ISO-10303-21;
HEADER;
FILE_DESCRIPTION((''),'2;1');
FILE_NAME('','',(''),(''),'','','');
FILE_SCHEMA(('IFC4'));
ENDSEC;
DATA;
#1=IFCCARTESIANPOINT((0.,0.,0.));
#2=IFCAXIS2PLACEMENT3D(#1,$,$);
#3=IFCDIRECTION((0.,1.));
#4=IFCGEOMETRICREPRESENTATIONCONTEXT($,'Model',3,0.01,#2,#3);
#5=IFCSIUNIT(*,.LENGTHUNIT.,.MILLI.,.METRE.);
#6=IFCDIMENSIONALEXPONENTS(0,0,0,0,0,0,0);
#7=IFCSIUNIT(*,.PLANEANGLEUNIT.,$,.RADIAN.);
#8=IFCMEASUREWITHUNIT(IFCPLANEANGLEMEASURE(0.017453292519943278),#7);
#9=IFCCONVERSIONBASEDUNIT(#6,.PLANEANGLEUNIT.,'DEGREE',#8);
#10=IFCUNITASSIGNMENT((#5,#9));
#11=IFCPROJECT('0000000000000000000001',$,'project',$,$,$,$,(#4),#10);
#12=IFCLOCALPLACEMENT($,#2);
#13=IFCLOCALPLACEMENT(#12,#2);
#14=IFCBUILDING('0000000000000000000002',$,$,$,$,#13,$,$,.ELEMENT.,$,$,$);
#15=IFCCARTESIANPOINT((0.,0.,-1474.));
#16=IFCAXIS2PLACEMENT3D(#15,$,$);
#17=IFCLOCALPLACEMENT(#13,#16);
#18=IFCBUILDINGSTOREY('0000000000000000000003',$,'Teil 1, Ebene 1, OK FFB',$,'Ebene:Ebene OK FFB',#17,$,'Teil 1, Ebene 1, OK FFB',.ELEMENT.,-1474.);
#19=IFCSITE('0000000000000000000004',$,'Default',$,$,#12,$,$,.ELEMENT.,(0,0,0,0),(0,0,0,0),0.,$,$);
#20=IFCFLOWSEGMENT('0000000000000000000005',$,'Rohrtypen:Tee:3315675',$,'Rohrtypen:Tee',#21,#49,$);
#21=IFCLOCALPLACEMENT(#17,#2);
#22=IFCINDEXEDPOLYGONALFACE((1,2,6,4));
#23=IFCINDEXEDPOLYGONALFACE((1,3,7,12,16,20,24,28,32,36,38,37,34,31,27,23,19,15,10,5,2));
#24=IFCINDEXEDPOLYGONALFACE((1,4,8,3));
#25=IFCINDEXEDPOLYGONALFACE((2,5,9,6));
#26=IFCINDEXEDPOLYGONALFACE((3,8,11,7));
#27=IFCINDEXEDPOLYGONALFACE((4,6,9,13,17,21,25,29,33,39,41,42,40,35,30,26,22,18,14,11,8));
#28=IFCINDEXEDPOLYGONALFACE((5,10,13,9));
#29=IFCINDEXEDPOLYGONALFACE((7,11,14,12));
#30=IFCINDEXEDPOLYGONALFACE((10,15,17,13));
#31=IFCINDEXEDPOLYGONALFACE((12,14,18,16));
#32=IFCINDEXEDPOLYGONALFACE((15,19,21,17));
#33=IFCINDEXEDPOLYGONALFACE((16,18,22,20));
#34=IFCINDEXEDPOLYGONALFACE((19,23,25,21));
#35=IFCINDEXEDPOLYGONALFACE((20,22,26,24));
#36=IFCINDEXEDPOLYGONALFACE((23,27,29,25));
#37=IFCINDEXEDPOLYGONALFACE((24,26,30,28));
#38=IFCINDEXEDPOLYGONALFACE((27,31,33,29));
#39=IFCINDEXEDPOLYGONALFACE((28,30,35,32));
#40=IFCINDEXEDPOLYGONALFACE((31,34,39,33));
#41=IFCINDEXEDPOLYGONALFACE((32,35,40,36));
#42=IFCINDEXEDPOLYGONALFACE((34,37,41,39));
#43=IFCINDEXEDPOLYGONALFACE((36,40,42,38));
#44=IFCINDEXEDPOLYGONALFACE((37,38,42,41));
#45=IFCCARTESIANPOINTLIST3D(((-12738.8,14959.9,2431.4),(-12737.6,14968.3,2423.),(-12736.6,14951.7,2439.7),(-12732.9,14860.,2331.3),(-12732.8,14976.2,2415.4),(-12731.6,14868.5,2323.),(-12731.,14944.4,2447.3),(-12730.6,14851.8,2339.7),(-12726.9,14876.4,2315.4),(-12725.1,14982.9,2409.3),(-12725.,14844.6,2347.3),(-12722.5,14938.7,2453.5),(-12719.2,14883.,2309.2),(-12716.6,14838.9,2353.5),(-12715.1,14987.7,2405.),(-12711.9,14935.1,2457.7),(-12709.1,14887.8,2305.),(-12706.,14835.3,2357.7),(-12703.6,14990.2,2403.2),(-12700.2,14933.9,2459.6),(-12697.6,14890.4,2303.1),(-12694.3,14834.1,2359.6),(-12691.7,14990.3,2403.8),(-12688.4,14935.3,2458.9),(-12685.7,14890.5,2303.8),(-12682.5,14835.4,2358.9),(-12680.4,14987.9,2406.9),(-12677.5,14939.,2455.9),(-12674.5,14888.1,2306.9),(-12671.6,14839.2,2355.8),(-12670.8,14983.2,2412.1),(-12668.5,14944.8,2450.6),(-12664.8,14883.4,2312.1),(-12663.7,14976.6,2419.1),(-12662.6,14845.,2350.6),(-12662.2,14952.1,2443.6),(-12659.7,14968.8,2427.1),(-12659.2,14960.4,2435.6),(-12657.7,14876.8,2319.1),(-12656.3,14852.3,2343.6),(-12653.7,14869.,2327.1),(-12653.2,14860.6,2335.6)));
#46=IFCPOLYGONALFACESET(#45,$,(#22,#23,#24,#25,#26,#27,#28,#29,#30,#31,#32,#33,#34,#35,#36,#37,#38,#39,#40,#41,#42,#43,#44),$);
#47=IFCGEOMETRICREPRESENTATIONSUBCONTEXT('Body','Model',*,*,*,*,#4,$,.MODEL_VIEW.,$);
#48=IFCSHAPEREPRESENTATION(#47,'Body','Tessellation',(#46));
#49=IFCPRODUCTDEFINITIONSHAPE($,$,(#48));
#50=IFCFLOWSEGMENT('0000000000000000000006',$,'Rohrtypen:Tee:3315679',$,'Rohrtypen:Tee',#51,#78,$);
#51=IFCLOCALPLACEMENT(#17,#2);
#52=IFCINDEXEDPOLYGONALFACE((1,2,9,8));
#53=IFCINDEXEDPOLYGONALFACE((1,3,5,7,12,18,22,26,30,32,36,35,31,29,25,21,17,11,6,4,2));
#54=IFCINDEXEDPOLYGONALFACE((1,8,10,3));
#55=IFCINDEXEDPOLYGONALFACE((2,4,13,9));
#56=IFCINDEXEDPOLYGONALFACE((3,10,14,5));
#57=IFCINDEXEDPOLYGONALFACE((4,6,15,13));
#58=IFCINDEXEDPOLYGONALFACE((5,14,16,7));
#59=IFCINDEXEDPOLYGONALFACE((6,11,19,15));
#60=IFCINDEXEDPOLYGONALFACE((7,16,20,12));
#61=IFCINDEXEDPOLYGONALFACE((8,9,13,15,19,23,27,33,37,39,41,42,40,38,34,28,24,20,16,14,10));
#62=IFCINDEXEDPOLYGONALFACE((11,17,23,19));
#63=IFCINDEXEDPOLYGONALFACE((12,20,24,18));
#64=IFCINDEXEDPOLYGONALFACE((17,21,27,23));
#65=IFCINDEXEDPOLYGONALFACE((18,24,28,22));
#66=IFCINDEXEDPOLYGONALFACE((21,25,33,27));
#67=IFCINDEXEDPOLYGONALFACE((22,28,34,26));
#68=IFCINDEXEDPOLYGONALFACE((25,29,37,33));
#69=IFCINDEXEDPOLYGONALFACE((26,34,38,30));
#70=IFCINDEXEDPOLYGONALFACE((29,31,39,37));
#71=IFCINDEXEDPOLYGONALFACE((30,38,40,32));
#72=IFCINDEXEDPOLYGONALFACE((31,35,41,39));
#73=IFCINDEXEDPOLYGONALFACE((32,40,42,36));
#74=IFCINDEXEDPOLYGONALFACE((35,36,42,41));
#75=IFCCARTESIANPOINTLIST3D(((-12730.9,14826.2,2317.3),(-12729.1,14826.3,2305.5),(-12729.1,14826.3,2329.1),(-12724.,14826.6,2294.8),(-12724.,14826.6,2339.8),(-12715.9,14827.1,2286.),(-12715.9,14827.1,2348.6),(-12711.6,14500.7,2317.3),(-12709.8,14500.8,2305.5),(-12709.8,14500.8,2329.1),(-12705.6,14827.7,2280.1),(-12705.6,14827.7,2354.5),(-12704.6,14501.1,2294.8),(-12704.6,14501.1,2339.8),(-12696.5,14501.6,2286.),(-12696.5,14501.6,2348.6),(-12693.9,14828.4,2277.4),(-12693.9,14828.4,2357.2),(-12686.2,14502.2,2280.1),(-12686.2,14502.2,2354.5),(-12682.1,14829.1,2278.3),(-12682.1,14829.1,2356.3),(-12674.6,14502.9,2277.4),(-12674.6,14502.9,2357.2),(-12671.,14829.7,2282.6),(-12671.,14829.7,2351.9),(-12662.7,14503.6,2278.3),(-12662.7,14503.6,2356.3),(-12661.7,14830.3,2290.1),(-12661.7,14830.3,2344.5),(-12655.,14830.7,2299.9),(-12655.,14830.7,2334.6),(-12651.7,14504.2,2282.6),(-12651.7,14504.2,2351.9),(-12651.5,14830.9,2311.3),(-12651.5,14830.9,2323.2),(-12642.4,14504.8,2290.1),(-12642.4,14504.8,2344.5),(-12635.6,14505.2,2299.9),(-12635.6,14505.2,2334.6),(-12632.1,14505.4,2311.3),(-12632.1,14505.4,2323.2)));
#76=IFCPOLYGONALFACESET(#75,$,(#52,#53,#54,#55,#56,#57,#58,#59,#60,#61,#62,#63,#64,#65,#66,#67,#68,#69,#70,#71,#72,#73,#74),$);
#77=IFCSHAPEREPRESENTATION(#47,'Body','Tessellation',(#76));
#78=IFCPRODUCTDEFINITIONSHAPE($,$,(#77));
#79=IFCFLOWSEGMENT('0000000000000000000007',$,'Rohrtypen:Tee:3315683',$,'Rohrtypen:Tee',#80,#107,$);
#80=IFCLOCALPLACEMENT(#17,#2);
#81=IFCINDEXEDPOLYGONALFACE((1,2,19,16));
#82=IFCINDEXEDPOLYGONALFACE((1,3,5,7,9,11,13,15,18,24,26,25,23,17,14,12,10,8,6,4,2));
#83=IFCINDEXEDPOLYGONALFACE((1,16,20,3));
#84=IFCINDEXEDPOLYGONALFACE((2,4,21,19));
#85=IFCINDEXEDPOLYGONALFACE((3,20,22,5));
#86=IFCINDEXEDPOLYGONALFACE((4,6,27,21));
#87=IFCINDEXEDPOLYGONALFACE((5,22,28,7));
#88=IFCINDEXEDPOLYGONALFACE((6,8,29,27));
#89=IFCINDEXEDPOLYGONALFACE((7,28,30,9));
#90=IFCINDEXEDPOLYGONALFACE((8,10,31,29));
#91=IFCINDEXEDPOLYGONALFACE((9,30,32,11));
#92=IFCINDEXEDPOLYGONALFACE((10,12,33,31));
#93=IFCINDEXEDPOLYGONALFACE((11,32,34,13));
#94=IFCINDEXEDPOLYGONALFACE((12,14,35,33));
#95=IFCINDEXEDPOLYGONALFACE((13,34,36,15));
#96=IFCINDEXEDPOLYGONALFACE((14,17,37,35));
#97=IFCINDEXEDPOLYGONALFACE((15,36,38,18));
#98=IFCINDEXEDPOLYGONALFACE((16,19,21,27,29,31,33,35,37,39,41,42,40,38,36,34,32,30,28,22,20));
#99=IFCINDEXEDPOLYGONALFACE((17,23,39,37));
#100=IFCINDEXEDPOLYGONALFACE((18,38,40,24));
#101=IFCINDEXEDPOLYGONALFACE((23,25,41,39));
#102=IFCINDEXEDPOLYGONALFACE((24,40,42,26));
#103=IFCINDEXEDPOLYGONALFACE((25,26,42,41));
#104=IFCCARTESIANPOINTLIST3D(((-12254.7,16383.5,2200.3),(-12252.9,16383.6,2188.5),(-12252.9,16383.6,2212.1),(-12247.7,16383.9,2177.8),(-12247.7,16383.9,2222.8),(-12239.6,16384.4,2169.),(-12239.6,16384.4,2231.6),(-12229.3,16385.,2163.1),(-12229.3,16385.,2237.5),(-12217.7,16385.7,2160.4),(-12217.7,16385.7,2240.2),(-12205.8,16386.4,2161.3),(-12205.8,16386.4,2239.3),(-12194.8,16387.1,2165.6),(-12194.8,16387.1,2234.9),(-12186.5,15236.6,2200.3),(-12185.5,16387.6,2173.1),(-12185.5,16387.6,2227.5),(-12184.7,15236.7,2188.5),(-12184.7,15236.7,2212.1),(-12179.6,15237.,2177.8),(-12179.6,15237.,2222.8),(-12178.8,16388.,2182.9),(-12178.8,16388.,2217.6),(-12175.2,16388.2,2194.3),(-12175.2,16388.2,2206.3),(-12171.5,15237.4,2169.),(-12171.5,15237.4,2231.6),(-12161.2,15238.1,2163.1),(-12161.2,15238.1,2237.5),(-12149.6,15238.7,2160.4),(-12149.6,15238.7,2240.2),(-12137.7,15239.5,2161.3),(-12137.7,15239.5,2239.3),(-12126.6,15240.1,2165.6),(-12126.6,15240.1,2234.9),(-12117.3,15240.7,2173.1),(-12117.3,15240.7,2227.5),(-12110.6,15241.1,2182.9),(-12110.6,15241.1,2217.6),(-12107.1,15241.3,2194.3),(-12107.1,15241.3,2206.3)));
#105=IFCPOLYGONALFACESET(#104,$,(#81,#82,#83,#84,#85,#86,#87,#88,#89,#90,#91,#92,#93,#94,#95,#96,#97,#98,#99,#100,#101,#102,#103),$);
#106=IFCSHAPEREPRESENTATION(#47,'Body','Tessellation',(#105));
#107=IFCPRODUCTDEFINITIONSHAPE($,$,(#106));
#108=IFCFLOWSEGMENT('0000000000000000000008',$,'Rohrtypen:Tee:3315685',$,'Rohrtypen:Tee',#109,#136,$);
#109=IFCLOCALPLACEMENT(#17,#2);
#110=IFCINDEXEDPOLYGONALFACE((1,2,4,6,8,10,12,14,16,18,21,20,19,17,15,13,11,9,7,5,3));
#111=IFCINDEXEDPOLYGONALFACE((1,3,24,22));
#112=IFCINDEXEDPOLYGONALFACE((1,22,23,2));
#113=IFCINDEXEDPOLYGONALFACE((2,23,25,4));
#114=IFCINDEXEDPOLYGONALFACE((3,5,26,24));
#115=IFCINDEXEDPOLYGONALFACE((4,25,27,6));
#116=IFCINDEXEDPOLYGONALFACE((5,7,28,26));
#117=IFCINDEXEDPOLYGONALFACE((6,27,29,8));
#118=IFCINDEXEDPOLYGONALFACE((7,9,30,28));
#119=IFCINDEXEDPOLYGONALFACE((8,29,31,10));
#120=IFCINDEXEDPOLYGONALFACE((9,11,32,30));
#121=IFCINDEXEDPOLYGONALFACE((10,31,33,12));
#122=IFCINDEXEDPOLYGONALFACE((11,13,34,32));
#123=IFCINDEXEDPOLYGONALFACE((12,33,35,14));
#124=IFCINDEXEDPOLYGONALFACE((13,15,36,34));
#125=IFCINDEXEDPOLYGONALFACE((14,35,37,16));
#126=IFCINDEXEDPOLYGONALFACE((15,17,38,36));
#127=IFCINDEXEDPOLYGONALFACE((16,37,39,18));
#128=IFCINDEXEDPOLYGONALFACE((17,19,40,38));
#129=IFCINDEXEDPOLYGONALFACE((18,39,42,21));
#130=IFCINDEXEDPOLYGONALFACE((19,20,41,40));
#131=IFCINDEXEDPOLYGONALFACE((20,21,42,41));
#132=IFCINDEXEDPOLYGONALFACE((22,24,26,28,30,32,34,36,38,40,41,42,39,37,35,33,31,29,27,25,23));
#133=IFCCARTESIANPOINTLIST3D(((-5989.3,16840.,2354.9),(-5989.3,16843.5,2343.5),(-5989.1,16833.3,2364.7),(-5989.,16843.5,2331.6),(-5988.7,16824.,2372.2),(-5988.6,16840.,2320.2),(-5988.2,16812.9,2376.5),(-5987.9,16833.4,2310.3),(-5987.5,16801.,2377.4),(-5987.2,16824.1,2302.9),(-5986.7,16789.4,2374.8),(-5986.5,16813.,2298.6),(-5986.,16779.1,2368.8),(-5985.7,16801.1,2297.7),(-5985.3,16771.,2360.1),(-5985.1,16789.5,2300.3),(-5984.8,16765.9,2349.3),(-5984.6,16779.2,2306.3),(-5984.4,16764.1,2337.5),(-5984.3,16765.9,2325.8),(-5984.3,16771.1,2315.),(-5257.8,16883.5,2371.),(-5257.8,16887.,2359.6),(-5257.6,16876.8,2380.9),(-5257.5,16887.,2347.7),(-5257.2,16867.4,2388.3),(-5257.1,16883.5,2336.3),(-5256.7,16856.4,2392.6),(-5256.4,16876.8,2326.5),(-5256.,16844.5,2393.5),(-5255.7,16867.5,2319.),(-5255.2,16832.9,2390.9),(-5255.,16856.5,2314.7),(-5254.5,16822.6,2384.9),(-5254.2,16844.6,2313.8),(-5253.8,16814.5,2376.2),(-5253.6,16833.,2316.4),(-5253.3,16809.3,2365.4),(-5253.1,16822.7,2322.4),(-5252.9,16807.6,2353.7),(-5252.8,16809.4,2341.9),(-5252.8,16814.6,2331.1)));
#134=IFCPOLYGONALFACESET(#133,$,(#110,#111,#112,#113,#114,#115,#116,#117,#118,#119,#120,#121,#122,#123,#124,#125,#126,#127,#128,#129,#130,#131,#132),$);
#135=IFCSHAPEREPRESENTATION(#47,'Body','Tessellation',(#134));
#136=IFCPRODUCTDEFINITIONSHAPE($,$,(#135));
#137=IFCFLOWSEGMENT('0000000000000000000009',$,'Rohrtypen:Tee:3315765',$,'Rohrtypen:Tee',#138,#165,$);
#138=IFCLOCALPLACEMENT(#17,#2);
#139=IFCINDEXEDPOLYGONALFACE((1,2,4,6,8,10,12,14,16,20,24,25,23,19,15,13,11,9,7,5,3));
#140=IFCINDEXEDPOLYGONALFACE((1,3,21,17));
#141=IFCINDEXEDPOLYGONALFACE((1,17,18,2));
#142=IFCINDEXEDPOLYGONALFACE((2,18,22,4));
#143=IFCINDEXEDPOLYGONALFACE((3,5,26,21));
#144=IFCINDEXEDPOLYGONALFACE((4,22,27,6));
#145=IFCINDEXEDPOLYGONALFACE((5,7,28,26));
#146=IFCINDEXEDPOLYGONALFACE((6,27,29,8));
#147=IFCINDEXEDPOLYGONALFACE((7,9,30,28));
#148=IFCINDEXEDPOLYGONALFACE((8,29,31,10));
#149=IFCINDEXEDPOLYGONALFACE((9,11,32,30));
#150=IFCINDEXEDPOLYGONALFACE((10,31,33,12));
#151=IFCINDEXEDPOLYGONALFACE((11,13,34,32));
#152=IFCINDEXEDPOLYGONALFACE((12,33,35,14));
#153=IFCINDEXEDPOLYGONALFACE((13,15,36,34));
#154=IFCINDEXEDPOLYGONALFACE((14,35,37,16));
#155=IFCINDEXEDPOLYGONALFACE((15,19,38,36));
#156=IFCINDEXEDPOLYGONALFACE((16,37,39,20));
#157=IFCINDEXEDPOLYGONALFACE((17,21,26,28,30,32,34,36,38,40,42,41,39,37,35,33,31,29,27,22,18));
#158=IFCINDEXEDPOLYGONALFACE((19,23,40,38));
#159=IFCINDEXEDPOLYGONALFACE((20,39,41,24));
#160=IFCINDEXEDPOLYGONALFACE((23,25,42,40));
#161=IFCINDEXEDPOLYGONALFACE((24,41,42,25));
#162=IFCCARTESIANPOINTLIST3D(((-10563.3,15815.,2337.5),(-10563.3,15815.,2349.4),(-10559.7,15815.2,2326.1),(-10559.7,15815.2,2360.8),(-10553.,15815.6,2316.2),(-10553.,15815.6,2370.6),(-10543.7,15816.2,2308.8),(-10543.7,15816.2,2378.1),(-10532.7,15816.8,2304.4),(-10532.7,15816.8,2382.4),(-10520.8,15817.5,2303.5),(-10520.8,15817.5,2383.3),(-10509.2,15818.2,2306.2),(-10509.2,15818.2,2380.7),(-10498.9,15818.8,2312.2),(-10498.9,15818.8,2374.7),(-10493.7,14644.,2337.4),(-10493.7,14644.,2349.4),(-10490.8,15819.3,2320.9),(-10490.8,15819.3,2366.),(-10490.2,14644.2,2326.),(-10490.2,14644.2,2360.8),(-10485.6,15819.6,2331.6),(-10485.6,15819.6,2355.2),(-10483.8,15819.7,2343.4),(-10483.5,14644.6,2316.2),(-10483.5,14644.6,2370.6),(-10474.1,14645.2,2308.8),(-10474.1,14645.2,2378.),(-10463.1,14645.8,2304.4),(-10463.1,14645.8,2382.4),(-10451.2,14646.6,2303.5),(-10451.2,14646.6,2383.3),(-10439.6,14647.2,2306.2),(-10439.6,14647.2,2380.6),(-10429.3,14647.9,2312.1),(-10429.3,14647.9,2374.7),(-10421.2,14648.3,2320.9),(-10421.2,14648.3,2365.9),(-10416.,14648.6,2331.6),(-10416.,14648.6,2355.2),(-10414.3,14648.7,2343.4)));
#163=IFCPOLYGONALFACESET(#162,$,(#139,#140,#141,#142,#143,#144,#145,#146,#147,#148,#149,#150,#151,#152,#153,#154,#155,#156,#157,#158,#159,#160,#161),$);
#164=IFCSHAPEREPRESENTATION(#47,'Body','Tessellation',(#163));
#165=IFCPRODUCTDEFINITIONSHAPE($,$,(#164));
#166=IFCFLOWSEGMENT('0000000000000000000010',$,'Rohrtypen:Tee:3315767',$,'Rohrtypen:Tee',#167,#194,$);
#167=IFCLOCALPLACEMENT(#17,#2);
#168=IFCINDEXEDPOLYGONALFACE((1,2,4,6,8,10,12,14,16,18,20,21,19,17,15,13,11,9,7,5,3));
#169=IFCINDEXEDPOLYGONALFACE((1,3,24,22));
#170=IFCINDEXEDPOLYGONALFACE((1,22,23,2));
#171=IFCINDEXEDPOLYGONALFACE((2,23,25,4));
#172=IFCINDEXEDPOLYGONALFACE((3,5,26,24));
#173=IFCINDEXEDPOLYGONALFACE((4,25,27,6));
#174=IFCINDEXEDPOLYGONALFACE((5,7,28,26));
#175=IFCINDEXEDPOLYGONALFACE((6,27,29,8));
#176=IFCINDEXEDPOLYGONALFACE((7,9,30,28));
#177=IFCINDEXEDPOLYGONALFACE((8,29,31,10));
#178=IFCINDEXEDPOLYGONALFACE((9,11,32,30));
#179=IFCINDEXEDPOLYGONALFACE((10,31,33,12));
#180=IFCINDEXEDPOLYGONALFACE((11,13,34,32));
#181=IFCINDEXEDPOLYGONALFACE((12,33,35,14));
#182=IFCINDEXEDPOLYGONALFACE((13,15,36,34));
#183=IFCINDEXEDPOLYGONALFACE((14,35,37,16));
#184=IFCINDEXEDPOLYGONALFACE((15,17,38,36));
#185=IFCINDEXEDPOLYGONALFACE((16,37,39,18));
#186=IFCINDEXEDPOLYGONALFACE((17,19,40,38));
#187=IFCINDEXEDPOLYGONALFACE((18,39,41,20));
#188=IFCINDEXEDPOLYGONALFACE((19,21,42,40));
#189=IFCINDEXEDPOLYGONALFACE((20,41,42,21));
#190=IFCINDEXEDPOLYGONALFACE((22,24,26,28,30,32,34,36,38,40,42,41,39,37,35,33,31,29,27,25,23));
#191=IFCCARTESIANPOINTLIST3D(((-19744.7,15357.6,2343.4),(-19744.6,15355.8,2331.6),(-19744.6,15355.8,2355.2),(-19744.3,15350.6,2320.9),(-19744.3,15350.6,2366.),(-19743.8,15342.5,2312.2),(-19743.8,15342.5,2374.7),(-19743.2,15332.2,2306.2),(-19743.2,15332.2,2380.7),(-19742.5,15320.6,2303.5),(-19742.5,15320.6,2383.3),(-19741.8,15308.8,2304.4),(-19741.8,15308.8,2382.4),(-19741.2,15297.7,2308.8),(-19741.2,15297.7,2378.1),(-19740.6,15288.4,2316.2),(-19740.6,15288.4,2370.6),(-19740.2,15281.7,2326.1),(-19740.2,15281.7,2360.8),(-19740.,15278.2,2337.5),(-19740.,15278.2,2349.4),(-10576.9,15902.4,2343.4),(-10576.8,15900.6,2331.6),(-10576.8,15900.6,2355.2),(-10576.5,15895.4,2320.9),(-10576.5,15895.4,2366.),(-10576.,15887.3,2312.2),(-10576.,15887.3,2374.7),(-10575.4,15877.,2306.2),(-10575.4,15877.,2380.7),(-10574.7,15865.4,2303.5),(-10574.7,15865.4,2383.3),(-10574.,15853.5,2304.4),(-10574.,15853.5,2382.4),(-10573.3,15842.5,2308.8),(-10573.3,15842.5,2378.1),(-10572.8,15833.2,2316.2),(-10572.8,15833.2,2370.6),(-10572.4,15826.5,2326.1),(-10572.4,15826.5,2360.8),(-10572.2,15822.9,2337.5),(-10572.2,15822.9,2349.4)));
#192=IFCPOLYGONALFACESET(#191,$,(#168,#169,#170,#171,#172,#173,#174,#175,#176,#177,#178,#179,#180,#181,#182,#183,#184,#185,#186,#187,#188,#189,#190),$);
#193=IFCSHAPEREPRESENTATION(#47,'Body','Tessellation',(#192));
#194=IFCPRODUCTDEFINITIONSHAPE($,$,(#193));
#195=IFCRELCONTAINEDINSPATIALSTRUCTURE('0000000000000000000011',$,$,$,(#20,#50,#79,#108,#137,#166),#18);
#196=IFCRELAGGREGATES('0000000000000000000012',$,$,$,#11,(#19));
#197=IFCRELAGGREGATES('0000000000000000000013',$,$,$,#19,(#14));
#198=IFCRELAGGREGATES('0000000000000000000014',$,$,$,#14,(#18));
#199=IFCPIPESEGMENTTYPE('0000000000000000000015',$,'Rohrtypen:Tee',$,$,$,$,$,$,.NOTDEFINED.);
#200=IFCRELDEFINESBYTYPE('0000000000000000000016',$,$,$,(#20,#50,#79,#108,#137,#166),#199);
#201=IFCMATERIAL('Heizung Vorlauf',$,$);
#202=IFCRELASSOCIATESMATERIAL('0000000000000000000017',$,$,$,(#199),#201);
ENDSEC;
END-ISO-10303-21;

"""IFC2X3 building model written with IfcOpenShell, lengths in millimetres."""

from ifc_helpers import new_model, entity, si_unit, converted_unit, direction, frame, frame_2d, origin, origin_2d_with_axis, place, context, subcontext, project, spatial, circle, extrude, material, type_object, element, save


model = new_model("IFC2X3")

# Units and contexts
model_context = context("Model", 3, precision=0.01, world=origin(), true_north=direction((0.0, 1.0)))
body_context = subcontext(model_context, "Body", "Model", "MODEL_VIEW")
ifc_project = project(units=[si_unit("LENGTHUNIT", "METRE", prefix="MILLI"), converted_unit("PLANEANGLEUNIT", "DEGREE", entity("IfcPlaneAngleMeasure", 0.017453292519943278), si_unit("PLANEANGLEUNIT", "RADIAN"), dimensions=[0, 0, 0, 0, 0, 0, 0])], contexts=[model_context])

# Site, building, storey
site_placement = place(None, origin())
site = spatial("IfcSite", under=ifc_project, at=site_placement, Name="Default", CompositionType="ELEMENT", RefLatitude=(0, 0, 0, 0), RefLongitude=(0, 0, 0, 0), RefElevation=0.0)
building_placement = place(site_placement, origin())
building = spatial("IfcBuilding", under=site, at=building_placement, CompositionType="ELEMENT")
storey_placement = place(building_placement, frame((0.0, 0.0, -1474.0)))
storey = spatial("IfcBuildingStorey", under=building, at=storey_placement, Name="Teil 1, Ebene 1, OK FFB", ObjectType="Ebene:Ebene OK FFB", LongName="Teil 1, Ebene 1, OK FFB", CompositionType="ELEMENT", Elevation=-1474.0)

# Flow segments
ifc_material = material(Name="Heizung Vorlauf")
pipe_segment_type = type_object("IfcPipeSegmentType", Name="Rohrtypen:Tee", PredefinedType="NOTDEFINED", material=ifc_material)
flow_segment_1_placement = place(storey_placement, origin())
element("IfcFlowSegment", 1, at=flow_segment_1_placement, inside=storey, type_object=pipe_segment_type, Name="Rohrtypen:Tee:3315675", ObjectType="Rohrtypen:Tee", context=body_context, shape_type="SweptSolid", body=[
    extrude(circle(Radius=40.0, at=frame_2d((0.0, 0.0), x_axis=(1.0, 0.0))), frame((-12693.0, 14862.4, 2331.3), z_axis=(-0.041945, 0.705862, 0.707107), x_axis=(-0.998239, -0.059319, 0.0)), (0.0, 0.0, 1.0), 141.4),
])
flow_segment_2_placement = place(storey_placement, origin())
element("IfcFlowSegment", 2, at=flow_segment_2_placement, inside=storey, type_object=pipe_segment_type, Name="Rohrtypen:Tee:3315679", ObjectType="Rohrtypen:Tee", context=body_context, shape_type="SweptSolid", body=[
    extrude(circle(Radius=40.0, at=origin_2d_with_axis()), frame((-12691.0, 14828.5, 2317.3), z_axis=(0.059319, -0.998239, 0.0), x_axis=(-0.998239, -0.059319, 0.0)), (0.0, 0.0, 1.0), 326.1),
])
flow_segment_3_placement = place(storey_placement, origin())
element("IfcFlowSegment", 3, at=flow_segment_3_placement, inside=storey, type_object=pipe_segment_type, Name="Rohrtypen:Tee:3315683", ObjectType="Rohrtypen:Tee", context=body_context, shape_type="SweptSolid", body=[
    extrude(circle(Radius=40.0, at=frame_2d((0.0, 0.0), x_axis=(1.0, 0.0))), frame((-12214.7, 16385.9, 2200.3), z_axis=(0.059319, -0.998239, 0.0), x_axis=(-0.998239, -0.059319, 0.0)), (0.0, 0.0, 1.0), 1149.0),
])
flow_segment_4_placement = place(storey_placement, origin())
element("IfcFlowSegment", 4, at=flow_segment_4_placement, inside=storey, type_object=pipe_segment_type, Name="Rohrtypen:Tee:3315685", ObjectType="Rohrtypen:Tee", context=body_context, shape_type="SweptSolid", body=[
    extrude(circle(Radius=40.0, at=frame_2d((0.0, 0.0), x_axis=(1.0, 0.0))), frame((-5986.8, 16804.0, 2337.5), z_axis=(0.997998, 0.059305, 0.021984), x_axis=(0.059319, -0.998239, 0.0)), (0.0, 0.0, 1.0), 733.0),
])
flow_segment_5_placement = place(storey_placement, origin())
element("IfcFlowSegment", 5, at=flow_segment_5_placement, inside=storey, type_object=pipe_segment_type, Name="Rohrtypen:Tee:3315765", ObjectType="Rohrtypen:Tee", context=body_context, shape_type="SweptSolid", body=[
    extrude(circle(Radius=40.0, at=origin_2d_with_axis()), frame((-10454.2, 14646.4, 2343.4), z_axis=(-0.059319, 0.998239, 0.000031), x_axis=(0.998239, 0.059319, 0.0)), (0.0, 0.0, 1.0), 1173.1),
])
flow_segment_6_placement = place(storey_placement, origin())
element("IfcFlowSegment", 6, at=flow_segment_6_placement, inside=storey, type_object=pipe_segment_type, Name="Rohrtypen:Tee:3315767", ObjectType="Rohrtypen:Tee", context=body_context, shape_type="SweptSolid", body=[
    extrude(circle(Radius=40.0, at=frame_2d((0.0, 0.0), x_axis=(1.0, 0.0))), frame((-19742.4, 15317.6, 2343.4), z_axis=(0.998239, 0.059319, 0.0), x_axis=(-0.059319, 0.998239, 0.0)), (0.0, 0.0, 1.0), 9184.0),
])

save(model, "model.ifc")
